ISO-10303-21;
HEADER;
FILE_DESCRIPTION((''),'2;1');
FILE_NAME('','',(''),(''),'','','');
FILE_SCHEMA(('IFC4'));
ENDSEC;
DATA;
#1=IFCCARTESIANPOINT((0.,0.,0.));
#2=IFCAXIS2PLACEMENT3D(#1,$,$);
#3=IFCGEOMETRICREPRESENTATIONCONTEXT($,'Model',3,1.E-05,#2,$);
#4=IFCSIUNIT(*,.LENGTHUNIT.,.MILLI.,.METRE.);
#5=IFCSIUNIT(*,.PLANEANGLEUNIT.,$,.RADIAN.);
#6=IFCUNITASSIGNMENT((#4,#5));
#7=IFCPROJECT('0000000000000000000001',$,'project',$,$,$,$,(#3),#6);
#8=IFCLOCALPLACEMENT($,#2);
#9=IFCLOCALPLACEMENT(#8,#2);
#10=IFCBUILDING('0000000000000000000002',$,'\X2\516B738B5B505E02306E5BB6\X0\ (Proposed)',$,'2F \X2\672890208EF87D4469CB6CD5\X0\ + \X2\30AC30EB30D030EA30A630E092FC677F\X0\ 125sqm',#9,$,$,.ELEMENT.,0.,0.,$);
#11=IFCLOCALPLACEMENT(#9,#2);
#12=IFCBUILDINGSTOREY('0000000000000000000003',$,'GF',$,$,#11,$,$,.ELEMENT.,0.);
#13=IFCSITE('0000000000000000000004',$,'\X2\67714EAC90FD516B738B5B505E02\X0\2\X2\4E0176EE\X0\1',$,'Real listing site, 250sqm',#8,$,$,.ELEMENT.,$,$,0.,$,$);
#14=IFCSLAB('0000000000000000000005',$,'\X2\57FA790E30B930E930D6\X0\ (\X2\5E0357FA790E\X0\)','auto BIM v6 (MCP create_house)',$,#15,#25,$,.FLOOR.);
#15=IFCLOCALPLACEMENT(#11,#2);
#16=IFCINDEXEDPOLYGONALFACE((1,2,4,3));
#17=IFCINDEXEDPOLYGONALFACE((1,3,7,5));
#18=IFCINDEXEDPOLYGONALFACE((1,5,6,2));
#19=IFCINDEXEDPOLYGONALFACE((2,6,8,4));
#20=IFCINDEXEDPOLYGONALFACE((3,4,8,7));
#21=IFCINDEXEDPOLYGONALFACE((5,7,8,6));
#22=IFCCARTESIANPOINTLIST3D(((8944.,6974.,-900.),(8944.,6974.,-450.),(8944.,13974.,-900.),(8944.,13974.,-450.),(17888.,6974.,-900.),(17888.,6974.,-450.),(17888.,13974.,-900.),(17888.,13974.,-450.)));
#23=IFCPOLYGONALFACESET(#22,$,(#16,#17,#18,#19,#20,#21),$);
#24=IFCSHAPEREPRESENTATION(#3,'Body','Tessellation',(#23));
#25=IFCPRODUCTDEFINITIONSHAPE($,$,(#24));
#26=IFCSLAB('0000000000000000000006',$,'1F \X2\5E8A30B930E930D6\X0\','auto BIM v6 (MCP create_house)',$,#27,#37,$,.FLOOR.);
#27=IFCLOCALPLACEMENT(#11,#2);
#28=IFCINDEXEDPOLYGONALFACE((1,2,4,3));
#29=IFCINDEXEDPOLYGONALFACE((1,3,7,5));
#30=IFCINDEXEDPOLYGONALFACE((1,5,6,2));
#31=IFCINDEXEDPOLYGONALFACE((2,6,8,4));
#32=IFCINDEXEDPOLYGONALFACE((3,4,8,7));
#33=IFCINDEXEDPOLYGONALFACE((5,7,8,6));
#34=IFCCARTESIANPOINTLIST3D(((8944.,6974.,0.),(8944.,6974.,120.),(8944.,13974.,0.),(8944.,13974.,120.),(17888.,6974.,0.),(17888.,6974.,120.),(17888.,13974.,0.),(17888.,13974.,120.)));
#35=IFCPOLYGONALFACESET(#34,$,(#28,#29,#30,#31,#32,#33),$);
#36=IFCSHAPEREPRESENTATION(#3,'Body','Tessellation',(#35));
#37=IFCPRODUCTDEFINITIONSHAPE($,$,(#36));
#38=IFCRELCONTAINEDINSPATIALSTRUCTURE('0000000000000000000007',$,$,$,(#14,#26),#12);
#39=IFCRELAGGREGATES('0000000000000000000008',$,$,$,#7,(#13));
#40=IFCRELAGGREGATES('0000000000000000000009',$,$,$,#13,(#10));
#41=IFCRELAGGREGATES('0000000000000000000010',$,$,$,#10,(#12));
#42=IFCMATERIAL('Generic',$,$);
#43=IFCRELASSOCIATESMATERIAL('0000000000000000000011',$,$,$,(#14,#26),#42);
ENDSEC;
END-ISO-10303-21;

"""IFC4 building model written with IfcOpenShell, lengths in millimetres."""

from ifc_helpers import new_model, si_unit, frame, frame_2d, origin, place, context, project, spatial, rectangle, extrude, material, element, save


model = new_model("IFC4")

# Units and contexts
model_context = context("Model", 3, precision=1e-05, world=origin())
ifc_project = project(units=[si_unit("LENGTHUNIT", "METRE", prefix="MILLI"), si_unit("PLANEANGLEUNIT", "RADIAN")], contexts=[model_context])

# Site, building, storey
site_placement = place(None, origin())
site = spatial("IfcSite", under=ifc_project, at=site_placement, Name="東京都八王子市2丁目1", ObjectType="Real listing site, 250sqm", CompositionType="ELEMENT", RefElevation=0.0)
building_placement = place(site_placement, origin())
building = spatial("IfcBuilding", under=site, at=building_placement, Name="八王子市の家 (Proposed)", ObjectType="2F 木造軸組構法 + ガルバリウム鋼板 125sqm", CompositionType="ELEMENT", ElevationOfRefHeight=0.0, ElevationOfTerrain=0.0)
storey_placement = place(building_placement, origin())
storey = spatial("IfcBuildingStorey", under=building, at=storey_placement, Name="GF", CompositionType="ELEMENT", Elevation=0.0)

# Slabs
ifc_material = material(Name="Generic")
slab_1_placement = place(storey_placement, frame((4472.0, 3487.0, -450.0)))
element("IfcSlab", 1, at=slab_1_placement, inside=storey, material=ifc_material, Name="基礎スラブ (布基礎)", Description="auto BIM v6 (MCP create_house)", PredefinedType="FLOOR", context=model_context, shape_type="SweptSolid", body=[
    extrude(rectangle(XDim=8944.0, YDim=7000.0, at=frame_2d((4472.0, 3500.0))), frame((4472.0, 3487.0, -450.0)), (0.0, 0.0, 1.0), 450.0),
])
slab_2_placement = place(storey_placement, frame((4472.0, 3487.0, 0.0)))
element("IfcSlab", 2, at=slab_2_placement, inside=storey, material=ifc_material, Name="1F 床スラブ", Description="auto BIM v6 (MCP create_house)", PredefinedType="FLOOR", context=model_context, shape_type="SweptSolid", body=[
    extrude(rectangle(XDim=8944.0, YDim=7000.0, at=frame_2d((4472.0, 3500.0))), frame((4472.0, 3487.0, 0.0)), (0.0, 0.0, 1.0), 120.0),
])

save(model, "model.ifc")
